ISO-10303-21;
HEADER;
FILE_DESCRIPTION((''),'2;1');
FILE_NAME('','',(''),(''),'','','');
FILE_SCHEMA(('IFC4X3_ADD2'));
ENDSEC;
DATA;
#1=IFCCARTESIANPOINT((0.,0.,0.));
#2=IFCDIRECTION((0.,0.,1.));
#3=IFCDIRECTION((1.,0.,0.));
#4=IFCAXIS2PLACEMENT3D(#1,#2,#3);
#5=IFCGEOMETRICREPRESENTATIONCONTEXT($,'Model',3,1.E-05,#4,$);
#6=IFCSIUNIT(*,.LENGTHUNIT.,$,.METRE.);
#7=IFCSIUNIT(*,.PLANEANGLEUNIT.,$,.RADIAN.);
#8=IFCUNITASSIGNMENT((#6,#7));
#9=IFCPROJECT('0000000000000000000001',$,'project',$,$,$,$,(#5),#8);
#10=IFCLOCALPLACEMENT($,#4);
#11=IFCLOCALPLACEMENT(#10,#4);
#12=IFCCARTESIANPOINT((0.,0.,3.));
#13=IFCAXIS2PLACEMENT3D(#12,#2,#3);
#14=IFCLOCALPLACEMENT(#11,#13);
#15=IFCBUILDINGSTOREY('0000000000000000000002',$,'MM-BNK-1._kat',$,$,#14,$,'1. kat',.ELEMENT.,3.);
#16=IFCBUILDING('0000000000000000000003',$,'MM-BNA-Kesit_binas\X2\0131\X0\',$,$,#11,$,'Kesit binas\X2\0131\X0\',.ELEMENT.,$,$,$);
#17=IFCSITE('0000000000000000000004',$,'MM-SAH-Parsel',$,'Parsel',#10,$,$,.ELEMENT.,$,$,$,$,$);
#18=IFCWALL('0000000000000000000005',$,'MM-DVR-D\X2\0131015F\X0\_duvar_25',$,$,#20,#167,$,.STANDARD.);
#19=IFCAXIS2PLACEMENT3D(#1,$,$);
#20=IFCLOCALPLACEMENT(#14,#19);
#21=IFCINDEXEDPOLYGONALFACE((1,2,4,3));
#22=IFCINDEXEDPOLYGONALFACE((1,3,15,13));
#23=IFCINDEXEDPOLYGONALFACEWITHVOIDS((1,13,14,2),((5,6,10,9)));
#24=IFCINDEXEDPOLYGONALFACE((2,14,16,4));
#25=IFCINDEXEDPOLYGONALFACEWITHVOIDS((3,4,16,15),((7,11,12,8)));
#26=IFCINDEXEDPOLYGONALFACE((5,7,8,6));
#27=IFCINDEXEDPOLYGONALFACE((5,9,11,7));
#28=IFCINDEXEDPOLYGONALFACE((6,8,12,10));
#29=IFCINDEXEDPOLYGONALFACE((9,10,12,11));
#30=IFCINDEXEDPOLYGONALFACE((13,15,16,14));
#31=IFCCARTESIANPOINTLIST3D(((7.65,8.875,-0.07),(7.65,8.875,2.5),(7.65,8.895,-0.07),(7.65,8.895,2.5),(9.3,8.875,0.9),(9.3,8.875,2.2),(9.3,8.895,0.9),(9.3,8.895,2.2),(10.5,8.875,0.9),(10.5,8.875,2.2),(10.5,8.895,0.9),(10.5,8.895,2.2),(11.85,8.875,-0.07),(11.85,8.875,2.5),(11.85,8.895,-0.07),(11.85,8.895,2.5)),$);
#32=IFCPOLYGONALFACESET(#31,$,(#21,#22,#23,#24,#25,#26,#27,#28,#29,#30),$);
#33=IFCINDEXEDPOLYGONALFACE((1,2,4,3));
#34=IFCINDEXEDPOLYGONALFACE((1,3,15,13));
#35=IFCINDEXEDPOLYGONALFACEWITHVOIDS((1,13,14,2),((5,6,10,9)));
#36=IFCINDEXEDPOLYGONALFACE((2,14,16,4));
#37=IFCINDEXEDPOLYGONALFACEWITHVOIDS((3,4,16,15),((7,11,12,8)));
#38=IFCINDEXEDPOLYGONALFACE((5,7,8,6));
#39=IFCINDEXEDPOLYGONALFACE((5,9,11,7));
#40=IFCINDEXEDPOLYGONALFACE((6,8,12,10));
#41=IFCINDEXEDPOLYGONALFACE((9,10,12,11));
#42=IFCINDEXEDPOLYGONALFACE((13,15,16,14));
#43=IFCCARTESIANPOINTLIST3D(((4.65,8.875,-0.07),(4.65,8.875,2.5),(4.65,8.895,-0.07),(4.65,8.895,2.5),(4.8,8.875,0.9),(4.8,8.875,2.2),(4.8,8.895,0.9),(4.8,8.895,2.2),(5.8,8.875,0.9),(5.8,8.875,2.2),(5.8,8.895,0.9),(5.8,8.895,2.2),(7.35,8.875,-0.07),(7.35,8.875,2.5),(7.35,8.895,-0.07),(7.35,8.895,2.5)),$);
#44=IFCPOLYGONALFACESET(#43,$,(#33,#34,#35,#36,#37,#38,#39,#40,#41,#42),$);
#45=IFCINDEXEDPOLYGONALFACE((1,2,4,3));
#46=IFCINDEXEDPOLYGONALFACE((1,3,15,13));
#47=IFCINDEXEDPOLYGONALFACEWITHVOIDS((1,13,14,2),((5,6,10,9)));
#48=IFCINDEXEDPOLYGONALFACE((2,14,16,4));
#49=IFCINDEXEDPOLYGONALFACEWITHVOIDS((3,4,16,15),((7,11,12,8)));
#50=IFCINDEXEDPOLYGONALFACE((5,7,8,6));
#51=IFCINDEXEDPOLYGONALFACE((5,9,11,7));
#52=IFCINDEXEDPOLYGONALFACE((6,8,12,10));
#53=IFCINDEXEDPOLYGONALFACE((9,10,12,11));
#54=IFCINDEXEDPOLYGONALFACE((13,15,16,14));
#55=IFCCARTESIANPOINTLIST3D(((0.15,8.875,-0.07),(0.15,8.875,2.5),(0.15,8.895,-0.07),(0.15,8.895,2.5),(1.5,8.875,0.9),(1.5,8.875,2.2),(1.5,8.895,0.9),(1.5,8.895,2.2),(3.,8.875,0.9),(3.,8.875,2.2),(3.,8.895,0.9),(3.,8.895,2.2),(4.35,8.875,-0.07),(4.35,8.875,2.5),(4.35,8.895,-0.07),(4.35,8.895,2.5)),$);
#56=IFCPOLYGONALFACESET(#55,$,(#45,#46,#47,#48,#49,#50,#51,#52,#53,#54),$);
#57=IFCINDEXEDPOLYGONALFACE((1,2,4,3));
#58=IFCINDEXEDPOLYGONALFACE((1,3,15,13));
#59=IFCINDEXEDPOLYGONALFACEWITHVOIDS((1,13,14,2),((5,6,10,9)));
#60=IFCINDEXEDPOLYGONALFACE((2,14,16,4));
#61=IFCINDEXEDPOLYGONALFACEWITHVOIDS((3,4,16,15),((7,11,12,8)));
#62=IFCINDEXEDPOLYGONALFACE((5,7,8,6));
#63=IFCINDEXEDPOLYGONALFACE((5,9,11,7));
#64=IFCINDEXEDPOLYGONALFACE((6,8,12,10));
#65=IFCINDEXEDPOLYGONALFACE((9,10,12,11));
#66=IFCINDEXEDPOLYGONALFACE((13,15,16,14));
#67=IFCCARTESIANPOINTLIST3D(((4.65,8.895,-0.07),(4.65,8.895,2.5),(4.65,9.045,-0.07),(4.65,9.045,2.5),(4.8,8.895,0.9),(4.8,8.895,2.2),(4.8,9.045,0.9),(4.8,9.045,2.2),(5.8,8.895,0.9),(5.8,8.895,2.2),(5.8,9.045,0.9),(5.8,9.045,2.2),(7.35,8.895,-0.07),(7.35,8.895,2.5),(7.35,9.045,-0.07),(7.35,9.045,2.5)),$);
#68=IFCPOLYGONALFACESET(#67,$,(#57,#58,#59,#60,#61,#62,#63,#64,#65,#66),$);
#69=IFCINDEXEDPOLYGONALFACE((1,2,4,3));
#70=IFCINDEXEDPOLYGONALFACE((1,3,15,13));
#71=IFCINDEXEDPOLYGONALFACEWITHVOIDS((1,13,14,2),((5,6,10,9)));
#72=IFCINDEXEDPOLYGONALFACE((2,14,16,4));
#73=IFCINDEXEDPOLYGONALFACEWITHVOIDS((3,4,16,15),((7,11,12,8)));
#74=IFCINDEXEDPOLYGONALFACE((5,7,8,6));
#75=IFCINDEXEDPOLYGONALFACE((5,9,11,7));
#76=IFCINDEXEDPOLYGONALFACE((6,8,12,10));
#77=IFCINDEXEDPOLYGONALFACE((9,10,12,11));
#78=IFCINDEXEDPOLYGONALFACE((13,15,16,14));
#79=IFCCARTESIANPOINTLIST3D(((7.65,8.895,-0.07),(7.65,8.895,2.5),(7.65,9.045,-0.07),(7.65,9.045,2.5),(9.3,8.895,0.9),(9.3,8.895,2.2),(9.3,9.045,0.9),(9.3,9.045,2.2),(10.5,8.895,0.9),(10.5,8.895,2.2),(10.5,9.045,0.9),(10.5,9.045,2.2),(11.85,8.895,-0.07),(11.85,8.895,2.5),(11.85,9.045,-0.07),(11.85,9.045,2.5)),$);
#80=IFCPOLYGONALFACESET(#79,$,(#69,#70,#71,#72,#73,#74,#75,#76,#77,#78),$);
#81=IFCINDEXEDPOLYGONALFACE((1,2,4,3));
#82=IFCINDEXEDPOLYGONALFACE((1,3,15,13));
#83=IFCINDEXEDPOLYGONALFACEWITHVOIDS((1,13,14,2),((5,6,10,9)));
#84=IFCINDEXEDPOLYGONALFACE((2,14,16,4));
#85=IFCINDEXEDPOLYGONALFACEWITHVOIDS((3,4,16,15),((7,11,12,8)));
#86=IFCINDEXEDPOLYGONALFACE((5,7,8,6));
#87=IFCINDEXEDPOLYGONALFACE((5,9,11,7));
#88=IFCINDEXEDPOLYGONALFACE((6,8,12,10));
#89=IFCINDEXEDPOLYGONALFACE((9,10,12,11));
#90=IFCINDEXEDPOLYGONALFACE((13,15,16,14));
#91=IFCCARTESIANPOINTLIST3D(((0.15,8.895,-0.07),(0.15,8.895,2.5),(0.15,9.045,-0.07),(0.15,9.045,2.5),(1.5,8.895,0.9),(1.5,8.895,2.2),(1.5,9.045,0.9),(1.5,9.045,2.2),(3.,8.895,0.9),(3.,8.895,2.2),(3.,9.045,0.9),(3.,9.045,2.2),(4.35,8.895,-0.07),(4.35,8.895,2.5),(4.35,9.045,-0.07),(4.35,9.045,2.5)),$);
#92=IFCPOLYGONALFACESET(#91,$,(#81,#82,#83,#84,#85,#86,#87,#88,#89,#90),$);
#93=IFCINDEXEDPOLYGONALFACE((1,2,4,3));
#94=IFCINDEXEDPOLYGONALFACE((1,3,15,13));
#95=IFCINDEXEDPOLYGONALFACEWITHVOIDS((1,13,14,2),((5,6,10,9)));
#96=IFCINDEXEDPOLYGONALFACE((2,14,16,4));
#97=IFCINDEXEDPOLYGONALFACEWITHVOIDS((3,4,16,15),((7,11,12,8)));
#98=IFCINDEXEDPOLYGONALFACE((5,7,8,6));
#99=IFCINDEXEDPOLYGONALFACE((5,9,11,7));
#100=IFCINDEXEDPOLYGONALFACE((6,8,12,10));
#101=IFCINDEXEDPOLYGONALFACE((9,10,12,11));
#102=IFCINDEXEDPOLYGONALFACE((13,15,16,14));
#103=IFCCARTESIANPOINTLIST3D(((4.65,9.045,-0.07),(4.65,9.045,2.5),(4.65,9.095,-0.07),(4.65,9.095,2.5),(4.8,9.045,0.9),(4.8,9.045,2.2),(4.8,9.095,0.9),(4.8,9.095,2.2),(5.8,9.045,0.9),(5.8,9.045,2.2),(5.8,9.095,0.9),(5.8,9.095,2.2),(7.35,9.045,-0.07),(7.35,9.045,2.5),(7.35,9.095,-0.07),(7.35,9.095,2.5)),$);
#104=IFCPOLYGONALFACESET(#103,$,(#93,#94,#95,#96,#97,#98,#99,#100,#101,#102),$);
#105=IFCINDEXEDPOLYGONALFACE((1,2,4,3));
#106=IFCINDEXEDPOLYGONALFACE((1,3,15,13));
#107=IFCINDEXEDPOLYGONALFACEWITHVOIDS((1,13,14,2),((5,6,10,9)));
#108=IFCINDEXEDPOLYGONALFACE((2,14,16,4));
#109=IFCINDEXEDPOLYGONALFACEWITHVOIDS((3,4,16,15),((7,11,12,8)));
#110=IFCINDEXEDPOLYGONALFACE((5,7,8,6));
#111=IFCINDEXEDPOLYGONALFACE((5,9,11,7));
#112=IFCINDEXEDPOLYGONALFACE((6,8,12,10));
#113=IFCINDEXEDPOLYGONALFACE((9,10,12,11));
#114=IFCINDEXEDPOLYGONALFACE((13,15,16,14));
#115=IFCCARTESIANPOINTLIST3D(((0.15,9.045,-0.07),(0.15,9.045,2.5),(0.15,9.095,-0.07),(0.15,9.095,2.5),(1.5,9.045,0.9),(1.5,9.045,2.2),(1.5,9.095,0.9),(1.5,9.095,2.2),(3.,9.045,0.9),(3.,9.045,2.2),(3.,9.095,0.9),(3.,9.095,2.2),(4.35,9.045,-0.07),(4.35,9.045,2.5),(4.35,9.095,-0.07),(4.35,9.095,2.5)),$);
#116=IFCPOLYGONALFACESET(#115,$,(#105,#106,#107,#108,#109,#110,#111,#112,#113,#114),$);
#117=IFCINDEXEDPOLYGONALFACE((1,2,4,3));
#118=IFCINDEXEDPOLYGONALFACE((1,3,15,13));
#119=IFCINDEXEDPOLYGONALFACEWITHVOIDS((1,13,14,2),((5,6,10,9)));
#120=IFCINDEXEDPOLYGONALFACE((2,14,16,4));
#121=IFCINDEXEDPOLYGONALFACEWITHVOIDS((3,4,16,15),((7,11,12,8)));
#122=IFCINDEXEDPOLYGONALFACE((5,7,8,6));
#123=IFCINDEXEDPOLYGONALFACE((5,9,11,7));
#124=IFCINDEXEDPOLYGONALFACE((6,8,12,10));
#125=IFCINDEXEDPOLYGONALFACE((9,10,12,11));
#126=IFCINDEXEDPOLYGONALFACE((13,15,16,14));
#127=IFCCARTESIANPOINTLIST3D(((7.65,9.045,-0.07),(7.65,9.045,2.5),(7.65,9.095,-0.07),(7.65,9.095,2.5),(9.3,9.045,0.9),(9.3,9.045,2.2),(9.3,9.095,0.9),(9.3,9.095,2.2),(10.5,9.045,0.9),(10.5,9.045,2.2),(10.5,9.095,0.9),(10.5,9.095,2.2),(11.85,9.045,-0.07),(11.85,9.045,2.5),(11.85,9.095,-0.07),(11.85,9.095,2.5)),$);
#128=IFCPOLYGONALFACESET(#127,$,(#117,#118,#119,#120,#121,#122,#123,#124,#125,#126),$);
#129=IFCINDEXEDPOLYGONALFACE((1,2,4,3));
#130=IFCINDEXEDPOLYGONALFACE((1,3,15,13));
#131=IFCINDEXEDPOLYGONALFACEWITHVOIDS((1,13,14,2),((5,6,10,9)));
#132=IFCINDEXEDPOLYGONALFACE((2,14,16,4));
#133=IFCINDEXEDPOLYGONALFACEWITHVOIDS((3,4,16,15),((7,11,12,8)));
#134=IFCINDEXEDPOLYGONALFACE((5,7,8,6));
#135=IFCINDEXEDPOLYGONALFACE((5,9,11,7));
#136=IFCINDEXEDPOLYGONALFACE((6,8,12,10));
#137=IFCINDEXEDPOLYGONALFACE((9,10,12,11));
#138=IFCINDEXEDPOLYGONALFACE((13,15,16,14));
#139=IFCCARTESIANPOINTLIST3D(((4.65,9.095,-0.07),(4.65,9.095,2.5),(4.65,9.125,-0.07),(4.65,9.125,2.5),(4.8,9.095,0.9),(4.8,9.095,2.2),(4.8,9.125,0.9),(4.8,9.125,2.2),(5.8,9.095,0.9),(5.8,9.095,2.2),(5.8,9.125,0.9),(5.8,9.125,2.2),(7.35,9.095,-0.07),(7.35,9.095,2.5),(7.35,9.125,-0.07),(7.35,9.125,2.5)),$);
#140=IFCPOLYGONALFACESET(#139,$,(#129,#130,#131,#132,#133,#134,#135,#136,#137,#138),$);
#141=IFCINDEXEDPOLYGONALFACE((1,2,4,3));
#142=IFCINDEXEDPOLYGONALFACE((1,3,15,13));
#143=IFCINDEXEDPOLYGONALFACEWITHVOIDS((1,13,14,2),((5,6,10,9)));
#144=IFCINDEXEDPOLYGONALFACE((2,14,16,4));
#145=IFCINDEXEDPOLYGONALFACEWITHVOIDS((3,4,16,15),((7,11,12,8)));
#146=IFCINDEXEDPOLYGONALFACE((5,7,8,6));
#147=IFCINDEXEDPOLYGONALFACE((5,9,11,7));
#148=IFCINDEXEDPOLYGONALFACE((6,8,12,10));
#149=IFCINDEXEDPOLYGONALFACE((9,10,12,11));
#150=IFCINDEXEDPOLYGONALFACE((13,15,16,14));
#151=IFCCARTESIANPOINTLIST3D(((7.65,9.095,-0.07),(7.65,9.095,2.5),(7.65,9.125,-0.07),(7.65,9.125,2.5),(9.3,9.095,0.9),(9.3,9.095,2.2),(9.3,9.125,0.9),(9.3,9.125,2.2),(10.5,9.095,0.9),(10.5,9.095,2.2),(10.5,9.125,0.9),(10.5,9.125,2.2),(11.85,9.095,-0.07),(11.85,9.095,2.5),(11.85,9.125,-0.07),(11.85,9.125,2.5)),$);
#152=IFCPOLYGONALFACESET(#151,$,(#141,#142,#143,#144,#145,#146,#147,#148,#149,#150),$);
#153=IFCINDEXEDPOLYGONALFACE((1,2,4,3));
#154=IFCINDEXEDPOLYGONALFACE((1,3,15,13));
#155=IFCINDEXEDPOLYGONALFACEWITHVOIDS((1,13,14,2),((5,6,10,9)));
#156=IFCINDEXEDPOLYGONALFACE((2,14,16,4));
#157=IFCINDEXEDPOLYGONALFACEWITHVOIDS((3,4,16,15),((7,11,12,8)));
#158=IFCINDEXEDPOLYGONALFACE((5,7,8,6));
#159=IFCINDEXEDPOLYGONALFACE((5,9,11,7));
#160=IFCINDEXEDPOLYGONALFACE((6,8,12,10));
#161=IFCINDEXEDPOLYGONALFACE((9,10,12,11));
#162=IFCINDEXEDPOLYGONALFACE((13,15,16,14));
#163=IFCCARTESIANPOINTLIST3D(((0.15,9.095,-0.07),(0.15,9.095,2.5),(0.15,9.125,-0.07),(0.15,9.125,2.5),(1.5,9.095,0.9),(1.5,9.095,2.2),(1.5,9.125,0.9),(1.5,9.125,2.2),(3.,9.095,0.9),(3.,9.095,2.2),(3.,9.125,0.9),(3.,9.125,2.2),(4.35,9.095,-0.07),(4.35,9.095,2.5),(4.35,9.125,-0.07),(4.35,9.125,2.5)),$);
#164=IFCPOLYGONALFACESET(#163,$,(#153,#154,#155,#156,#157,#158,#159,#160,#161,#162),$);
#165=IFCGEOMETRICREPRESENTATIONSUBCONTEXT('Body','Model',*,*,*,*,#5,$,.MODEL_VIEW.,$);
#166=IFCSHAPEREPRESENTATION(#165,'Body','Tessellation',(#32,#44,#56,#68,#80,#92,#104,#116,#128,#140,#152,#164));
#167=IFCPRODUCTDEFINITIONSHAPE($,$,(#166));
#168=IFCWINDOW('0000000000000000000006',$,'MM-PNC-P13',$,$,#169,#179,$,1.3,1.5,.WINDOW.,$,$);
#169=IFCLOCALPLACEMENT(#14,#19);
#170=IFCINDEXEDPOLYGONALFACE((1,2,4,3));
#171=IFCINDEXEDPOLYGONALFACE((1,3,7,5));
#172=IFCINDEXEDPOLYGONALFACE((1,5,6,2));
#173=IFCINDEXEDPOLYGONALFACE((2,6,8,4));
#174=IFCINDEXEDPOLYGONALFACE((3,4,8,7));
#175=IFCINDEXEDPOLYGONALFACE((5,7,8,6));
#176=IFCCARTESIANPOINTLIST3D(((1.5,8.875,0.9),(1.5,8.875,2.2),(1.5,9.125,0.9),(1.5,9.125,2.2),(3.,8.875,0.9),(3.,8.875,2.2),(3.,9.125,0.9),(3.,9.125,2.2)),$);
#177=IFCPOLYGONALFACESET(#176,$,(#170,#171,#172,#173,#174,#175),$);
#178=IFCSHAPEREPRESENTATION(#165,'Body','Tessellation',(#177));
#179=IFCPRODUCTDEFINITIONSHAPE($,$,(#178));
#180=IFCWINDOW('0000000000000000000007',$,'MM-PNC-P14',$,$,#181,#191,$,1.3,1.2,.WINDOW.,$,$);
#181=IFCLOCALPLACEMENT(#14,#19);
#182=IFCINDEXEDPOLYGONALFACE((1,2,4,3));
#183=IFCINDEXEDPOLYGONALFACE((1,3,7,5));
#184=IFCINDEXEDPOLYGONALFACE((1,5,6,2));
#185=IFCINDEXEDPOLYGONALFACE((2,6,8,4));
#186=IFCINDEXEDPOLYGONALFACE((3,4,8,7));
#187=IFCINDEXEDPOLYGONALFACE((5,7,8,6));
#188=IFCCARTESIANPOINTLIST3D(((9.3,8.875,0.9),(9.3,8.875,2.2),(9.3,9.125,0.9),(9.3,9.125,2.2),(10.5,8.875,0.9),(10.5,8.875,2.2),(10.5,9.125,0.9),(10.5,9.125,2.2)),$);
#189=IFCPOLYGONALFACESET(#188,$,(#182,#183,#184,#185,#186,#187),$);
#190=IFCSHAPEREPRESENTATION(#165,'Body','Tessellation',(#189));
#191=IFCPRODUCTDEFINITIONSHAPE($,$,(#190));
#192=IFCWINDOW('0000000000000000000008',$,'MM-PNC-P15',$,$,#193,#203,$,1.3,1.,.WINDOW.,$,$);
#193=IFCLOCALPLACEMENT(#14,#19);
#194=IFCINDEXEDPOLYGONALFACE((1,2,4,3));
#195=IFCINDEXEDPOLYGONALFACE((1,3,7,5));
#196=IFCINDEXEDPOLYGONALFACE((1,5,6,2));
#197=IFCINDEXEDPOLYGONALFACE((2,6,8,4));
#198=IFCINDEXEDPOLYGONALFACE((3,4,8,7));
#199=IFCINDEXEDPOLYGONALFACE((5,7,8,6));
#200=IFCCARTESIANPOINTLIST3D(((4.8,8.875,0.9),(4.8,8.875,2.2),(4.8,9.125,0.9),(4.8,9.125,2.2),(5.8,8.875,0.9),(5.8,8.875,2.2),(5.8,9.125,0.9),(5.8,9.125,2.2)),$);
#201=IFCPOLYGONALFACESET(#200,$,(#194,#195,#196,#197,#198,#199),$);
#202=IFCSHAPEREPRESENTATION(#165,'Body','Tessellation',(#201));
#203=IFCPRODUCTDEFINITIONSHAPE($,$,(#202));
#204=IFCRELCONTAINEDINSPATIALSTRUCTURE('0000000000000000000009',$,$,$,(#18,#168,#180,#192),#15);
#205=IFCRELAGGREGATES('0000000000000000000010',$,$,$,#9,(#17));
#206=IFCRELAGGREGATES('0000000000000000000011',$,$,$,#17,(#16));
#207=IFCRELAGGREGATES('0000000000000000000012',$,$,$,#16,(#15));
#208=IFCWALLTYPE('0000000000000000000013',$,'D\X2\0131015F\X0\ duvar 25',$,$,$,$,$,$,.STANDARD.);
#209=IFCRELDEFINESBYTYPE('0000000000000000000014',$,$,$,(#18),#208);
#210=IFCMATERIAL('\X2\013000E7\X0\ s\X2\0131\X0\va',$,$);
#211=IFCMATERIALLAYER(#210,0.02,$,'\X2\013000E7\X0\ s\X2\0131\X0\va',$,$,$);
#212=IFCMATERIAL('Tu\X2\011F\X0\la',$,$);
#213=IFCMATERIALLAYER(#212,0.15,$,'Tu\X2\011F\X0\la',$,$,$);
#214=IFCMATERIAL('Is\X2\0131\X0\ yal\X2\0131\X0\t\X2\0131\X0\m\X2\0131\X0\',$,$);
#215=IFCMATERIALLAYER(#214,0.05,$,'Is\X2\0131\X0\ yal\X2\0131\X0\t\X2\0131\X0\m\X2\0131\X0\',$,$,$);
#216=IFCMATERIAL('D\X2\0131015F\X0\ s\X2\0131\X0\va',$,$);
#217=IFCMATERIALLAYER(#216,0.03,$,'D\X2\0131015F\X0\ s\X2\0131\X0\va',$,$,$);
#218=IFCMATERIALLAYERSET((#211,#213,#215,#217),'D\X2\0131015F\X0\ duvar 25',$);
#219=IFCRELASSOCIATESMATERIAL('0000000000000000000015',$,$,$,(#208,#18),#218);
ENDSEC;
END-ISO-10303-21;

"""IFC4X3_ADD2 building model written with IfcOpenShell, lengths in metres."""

from ifc_helpers import new_model, si_unit, frame, origin_with_axes, place, context, subcontext, project, spatial, polyline, outline, extrude, material, layer, layer_set, type_object, element, fill, save


model = new_model("IFC4X3_ADD2")

# Units and contexts
model_context = context("Model", 3, precision=1e-05, world=origin_with_axes())
body_context = subcontext(model_context, "Body", "Model", "MODEL_VIEW")
ifc_project = project(units=[si_unit("LENGTHUNIT", "METRE"), si_unit("PLANEANGLEUNIT", "RADIAN")], contexts=[model_context])

# Site, building, storey
site_placement = place(None, origin_with_axes())
site = spatial("IfcSite", under=ifc_project, at=site_placement, Name="MM-SAH-Parsel", ObjectType="Parsel", CompositionType="ELEMENT")
building_placement = place(site_placement, origin_with_axes())
building = spatial("IfcBuilding", under=site, at=building_placement, Name="MM-BNA-Kesit_binası", LongName="Kesit binası", CompositionType="ELEMENT")
storey_placement = place(building_placement, frame((0.0, 0.0, 3.0), z_axis=(0.0, 0.0, 1.0), x_axis=(1.0, 0.0, 0.0)))
storey = spatial("IfcBuildingStorey", under=building, at=storey_placement, Name="MM-BNK-1._kat", LongName="1. kat", CompositionType="ELEMENT", Elevation=3.0)

# Shared definitions
ifc_material_1 = material(Name="İç sıva")
ifc_layer_1 = layer(ifc_material_1, 0.02, Name="İç sıva")
ifc_material_2 = material(Name="Tuğla")
ifc_layer_2 = layer(ifc_material_2, 0.15, Name="Tuğla")
ifc_material_3 = material(Name="Isı yalıtımı")
ifc_layer_3 = layer(ifc_material_3, 0.05, Name="Isı yalıtımı")
ifc_material_4 = material(Name="Dış sıva")
ifc_layer_4 = layer(ifc_material_4, 0.03, Name="Dış sıva")
ifc_layer_set_1 = layer_set([ifc_layer_1, ifc_layer_2, ifc_layer_3, ifc_layer_4], Name="Dış duvar 25")
wall_type_1 = type_object("IfcWallType", Name="Dış duvar 25", PredefinedType="STANDARD", material=ifc_layer_set_1)

# Wall, openings, windows
wall_1_placement = place(storey_placement, origin_with_axes())
wall_1 = element("IfcWall", 1, at=wall_1_placement, inside=storey, type_object=wall_type_1, material=ifc_layer_set_1, Name="MM-DVR-Dış_duvar_25", PredefinedType="STANDARD", context=body_context, shape_type="SweptSolid", body=[
    extrude(outline(polyline([(11.85, 8.895), (7.65, 8.895), (7.65, 8.875), (11.85, 8.875), (11.85, 8.895)])), frame((0.0, 0.0, -0.07)), (0.0, 0.0, 1.0), 2.57),
    extrude(outline(polyline([(7.35, 8.895), (4.65, 8.895), (4.65, 8.875), (7.35, 8.875), (7.35, 8.895)])), frame((0.0, 0.0, -0.07)), (0.0, 0.0, 1.0), 2.57),
    extrude(outline(polyline([(4.35, 8.895), (0.15, 8.895), (0.15, 8.875), (4.35, 8.875), (4.35, 8.895)])), frame((0.0, 0.0, -0.07)), (0.0, 0.0, 1.0), 2.57),
    extrude(outline(polyline([(7.35, 9.045), (4.65, 9.045), (4.65, 8.895), (7.35, 8.895), (7.35, 9.045)])), frame((0.0, 0.0, -0.07)), (0.0, 0.0, 1.0), 2.57),
    extrude(outline(polyline([(11.85, 9.045), (7.65, 9.045), (7.65, 8.895), (11.85, 8.895), (11.85, 9.045)])), frame((0.0, 0.0, -0.07)), (0.0, 0.0, 1.0), 2.57),
    extrude(outline(polyline([(4.35, 9.045), (0.15, 9.045), (0.15, 8.895), (4.35, 8.895), (4.35, 9.045)])), frame((0.0, 0.0, -0.07)), (0.0, 0.0, 1.0), 2.57),
    extrude(outline(polyline([(7.35, 9.095), (4.65, 9.095), (4.65, 9.045), (7.35, 9.045), (7.35, 9.095)])), frame((0.0, 0.0, -0.07)), (0.0, 0.0, 1.0), 2.57),
    extrude(outline(polyline([(4.35, 9.095), (0.15, 9.095), (0.15, 9.045), (4.35, 9.045), (4.35, 9.095)])), frame((0.0, 0.0, -0.07)), (0.0, 0.0, 1.0), 2.57),
    extrude(outline(polyline([(11.85, 9.095), (7.65, 9.095), (7.65, 9.045), (11.85, 9.045), (11.85, 9.095)])), frame((0.0, 0.0, -0.07)), (0.0, 0.0, 1.0), 2.57),
    extrude(outline(polyline([(7.35, 9.125), (4.65, 9.125), (4.65, 9.095), (7.35, 9.095), (7.35, 9.125)])), frame((0.0, 0.0, -0.07)), (0.0, 0.0, 1.0), 2.57),
    extrude(outline(polyline([(11.85, 9.125), (7.65, 9.125), (7.65, 9.095), (11.85, 9.095), (11.85, 9.125)])), frame((0.0, 0.0, -0.07)), (0.0, 0.0, 1.0), 2.57),
    extrude(outline(polyline([(4.35, 9.125), (0.15, 9.125), (0.15, 9.095), (4.35, 9.095), (4.35, 9.125)])), frame((0.0, 0.0, -0.07)), (0.0, 0.0, 1.0), 2.57),
])
opening_1_placement = place(storey_placement, origin_with_axes())
opening_1 = element("IfcOpeningElement", 2, at=opening_1_placement, cuts=wall_1, PredefinedType="OPENING", context=body_context, shape_type="SweptSolid", body=[
    extrude(outline(polyline([(3.0, 8.875), (1.5, 8.875), (1.5, 9.125), (3.0, 9.125), (3.0, 8.875)])), frame((0.0, 0.0, 0.9)), (0.0, 0.0, 1.0), 1.3),
])
opening_2_placement = place(storey_placement, origin_with_axes())
opening_2 = element("IfcOpeningElement", 3, at=opening_2_placement, cuts=wall_1, PredefinedType="OPENING", context=body_context, shape_type="SweptSolid", body=[
    extrude(outline(polyline([(10.5, 8.875), (9.3, 8.875), (9.3, 9.125), (10.5, 9.125), (10.5, 8.875)])), frame((0.0, 0.0, 0.9)), (0.0, 0.0, 1.0), 1.3),
])
opening_3_placement = place(storey_placement, origin_with_axes())
opening_3 = element("IfcOpeningElement", 4, at=opening_3_placement, cuts=wall_1, PredefinedType="OPENING", context=body_context, shape_type="SweptSolid", body=[
    extrude(outline(polyline([(5.8, 8.875), (4.8, 8.875), (4.8, 9.125), (5.8, 9.125), (5.8, 8.875)])), frame((0.0, 0.0, 0.9)), (0.0, 0.0, 1.0), 1.3),
])
window_1_placement = place(storey_placement, origin_with_axes())
window_1 = element("IfcWindow", 5, at=window_1_placement, inside=storey, Name="MM-PNC-P13", OverallHeight=1.3, OverallWidth=1.5, PredefinedType="WINDOW", context=body_context, shape_type="SweptSolid", body=[
    extrude(outline(polyline([(3.0, 8.875), (1.5, 8.875), (1.5, 9.125), (3.0, 9.125), (3.0, 8.875)])), frame((0.0, 0.0, 0.9)), (0.0, 0.0, 1.0), 1.3),
])
fill(opening_1, window_1)
window_2_placement = place(storey_placement, origin_with_axes())
window_2 = element("IfcWindow", 6, at=window_2_placement, inside=storey, Name="MM-PNC-P14", OverallHeight=1.3, OverallWidth=1.2, PredefinedType="WINDOW", context=body_context, shape_type="SweptSolid", body=[
    extrude(outline(polyline([(10.5, 8.875), (9.3, 8.875), (9.3, 9.125), (10.5, 9.125), (10.5, 8.875)])), frame((0.0, 0.0, 0.9)), (0.0, 0.0, 1.0), 1.3),
])
fill(opening_2, window_2)
window_3_placement = place(storey_placement, origin_with_axes())
window_3 = element("IfcWindow", 7, at=window_3_placement, inside=storey, Name="MM-PNC-P15", OverallHeight=1.3, OverallWidth=1.0, PredefinedType="WINDOW", context=body_context, shape_type="SweptSolid", body=[
    extrude(outline(polyline([(5.8, 8.875), (4.8, 8.875), (4.8, 9.125), (5.8, 9.125), (5.8, 8.875)])), frame((0.0, 0.0, 0.9)), (0.0, 0.0, 1.0), 1.3),
])
fill(opening_3, window_3)

save(model, "model.ifc")
